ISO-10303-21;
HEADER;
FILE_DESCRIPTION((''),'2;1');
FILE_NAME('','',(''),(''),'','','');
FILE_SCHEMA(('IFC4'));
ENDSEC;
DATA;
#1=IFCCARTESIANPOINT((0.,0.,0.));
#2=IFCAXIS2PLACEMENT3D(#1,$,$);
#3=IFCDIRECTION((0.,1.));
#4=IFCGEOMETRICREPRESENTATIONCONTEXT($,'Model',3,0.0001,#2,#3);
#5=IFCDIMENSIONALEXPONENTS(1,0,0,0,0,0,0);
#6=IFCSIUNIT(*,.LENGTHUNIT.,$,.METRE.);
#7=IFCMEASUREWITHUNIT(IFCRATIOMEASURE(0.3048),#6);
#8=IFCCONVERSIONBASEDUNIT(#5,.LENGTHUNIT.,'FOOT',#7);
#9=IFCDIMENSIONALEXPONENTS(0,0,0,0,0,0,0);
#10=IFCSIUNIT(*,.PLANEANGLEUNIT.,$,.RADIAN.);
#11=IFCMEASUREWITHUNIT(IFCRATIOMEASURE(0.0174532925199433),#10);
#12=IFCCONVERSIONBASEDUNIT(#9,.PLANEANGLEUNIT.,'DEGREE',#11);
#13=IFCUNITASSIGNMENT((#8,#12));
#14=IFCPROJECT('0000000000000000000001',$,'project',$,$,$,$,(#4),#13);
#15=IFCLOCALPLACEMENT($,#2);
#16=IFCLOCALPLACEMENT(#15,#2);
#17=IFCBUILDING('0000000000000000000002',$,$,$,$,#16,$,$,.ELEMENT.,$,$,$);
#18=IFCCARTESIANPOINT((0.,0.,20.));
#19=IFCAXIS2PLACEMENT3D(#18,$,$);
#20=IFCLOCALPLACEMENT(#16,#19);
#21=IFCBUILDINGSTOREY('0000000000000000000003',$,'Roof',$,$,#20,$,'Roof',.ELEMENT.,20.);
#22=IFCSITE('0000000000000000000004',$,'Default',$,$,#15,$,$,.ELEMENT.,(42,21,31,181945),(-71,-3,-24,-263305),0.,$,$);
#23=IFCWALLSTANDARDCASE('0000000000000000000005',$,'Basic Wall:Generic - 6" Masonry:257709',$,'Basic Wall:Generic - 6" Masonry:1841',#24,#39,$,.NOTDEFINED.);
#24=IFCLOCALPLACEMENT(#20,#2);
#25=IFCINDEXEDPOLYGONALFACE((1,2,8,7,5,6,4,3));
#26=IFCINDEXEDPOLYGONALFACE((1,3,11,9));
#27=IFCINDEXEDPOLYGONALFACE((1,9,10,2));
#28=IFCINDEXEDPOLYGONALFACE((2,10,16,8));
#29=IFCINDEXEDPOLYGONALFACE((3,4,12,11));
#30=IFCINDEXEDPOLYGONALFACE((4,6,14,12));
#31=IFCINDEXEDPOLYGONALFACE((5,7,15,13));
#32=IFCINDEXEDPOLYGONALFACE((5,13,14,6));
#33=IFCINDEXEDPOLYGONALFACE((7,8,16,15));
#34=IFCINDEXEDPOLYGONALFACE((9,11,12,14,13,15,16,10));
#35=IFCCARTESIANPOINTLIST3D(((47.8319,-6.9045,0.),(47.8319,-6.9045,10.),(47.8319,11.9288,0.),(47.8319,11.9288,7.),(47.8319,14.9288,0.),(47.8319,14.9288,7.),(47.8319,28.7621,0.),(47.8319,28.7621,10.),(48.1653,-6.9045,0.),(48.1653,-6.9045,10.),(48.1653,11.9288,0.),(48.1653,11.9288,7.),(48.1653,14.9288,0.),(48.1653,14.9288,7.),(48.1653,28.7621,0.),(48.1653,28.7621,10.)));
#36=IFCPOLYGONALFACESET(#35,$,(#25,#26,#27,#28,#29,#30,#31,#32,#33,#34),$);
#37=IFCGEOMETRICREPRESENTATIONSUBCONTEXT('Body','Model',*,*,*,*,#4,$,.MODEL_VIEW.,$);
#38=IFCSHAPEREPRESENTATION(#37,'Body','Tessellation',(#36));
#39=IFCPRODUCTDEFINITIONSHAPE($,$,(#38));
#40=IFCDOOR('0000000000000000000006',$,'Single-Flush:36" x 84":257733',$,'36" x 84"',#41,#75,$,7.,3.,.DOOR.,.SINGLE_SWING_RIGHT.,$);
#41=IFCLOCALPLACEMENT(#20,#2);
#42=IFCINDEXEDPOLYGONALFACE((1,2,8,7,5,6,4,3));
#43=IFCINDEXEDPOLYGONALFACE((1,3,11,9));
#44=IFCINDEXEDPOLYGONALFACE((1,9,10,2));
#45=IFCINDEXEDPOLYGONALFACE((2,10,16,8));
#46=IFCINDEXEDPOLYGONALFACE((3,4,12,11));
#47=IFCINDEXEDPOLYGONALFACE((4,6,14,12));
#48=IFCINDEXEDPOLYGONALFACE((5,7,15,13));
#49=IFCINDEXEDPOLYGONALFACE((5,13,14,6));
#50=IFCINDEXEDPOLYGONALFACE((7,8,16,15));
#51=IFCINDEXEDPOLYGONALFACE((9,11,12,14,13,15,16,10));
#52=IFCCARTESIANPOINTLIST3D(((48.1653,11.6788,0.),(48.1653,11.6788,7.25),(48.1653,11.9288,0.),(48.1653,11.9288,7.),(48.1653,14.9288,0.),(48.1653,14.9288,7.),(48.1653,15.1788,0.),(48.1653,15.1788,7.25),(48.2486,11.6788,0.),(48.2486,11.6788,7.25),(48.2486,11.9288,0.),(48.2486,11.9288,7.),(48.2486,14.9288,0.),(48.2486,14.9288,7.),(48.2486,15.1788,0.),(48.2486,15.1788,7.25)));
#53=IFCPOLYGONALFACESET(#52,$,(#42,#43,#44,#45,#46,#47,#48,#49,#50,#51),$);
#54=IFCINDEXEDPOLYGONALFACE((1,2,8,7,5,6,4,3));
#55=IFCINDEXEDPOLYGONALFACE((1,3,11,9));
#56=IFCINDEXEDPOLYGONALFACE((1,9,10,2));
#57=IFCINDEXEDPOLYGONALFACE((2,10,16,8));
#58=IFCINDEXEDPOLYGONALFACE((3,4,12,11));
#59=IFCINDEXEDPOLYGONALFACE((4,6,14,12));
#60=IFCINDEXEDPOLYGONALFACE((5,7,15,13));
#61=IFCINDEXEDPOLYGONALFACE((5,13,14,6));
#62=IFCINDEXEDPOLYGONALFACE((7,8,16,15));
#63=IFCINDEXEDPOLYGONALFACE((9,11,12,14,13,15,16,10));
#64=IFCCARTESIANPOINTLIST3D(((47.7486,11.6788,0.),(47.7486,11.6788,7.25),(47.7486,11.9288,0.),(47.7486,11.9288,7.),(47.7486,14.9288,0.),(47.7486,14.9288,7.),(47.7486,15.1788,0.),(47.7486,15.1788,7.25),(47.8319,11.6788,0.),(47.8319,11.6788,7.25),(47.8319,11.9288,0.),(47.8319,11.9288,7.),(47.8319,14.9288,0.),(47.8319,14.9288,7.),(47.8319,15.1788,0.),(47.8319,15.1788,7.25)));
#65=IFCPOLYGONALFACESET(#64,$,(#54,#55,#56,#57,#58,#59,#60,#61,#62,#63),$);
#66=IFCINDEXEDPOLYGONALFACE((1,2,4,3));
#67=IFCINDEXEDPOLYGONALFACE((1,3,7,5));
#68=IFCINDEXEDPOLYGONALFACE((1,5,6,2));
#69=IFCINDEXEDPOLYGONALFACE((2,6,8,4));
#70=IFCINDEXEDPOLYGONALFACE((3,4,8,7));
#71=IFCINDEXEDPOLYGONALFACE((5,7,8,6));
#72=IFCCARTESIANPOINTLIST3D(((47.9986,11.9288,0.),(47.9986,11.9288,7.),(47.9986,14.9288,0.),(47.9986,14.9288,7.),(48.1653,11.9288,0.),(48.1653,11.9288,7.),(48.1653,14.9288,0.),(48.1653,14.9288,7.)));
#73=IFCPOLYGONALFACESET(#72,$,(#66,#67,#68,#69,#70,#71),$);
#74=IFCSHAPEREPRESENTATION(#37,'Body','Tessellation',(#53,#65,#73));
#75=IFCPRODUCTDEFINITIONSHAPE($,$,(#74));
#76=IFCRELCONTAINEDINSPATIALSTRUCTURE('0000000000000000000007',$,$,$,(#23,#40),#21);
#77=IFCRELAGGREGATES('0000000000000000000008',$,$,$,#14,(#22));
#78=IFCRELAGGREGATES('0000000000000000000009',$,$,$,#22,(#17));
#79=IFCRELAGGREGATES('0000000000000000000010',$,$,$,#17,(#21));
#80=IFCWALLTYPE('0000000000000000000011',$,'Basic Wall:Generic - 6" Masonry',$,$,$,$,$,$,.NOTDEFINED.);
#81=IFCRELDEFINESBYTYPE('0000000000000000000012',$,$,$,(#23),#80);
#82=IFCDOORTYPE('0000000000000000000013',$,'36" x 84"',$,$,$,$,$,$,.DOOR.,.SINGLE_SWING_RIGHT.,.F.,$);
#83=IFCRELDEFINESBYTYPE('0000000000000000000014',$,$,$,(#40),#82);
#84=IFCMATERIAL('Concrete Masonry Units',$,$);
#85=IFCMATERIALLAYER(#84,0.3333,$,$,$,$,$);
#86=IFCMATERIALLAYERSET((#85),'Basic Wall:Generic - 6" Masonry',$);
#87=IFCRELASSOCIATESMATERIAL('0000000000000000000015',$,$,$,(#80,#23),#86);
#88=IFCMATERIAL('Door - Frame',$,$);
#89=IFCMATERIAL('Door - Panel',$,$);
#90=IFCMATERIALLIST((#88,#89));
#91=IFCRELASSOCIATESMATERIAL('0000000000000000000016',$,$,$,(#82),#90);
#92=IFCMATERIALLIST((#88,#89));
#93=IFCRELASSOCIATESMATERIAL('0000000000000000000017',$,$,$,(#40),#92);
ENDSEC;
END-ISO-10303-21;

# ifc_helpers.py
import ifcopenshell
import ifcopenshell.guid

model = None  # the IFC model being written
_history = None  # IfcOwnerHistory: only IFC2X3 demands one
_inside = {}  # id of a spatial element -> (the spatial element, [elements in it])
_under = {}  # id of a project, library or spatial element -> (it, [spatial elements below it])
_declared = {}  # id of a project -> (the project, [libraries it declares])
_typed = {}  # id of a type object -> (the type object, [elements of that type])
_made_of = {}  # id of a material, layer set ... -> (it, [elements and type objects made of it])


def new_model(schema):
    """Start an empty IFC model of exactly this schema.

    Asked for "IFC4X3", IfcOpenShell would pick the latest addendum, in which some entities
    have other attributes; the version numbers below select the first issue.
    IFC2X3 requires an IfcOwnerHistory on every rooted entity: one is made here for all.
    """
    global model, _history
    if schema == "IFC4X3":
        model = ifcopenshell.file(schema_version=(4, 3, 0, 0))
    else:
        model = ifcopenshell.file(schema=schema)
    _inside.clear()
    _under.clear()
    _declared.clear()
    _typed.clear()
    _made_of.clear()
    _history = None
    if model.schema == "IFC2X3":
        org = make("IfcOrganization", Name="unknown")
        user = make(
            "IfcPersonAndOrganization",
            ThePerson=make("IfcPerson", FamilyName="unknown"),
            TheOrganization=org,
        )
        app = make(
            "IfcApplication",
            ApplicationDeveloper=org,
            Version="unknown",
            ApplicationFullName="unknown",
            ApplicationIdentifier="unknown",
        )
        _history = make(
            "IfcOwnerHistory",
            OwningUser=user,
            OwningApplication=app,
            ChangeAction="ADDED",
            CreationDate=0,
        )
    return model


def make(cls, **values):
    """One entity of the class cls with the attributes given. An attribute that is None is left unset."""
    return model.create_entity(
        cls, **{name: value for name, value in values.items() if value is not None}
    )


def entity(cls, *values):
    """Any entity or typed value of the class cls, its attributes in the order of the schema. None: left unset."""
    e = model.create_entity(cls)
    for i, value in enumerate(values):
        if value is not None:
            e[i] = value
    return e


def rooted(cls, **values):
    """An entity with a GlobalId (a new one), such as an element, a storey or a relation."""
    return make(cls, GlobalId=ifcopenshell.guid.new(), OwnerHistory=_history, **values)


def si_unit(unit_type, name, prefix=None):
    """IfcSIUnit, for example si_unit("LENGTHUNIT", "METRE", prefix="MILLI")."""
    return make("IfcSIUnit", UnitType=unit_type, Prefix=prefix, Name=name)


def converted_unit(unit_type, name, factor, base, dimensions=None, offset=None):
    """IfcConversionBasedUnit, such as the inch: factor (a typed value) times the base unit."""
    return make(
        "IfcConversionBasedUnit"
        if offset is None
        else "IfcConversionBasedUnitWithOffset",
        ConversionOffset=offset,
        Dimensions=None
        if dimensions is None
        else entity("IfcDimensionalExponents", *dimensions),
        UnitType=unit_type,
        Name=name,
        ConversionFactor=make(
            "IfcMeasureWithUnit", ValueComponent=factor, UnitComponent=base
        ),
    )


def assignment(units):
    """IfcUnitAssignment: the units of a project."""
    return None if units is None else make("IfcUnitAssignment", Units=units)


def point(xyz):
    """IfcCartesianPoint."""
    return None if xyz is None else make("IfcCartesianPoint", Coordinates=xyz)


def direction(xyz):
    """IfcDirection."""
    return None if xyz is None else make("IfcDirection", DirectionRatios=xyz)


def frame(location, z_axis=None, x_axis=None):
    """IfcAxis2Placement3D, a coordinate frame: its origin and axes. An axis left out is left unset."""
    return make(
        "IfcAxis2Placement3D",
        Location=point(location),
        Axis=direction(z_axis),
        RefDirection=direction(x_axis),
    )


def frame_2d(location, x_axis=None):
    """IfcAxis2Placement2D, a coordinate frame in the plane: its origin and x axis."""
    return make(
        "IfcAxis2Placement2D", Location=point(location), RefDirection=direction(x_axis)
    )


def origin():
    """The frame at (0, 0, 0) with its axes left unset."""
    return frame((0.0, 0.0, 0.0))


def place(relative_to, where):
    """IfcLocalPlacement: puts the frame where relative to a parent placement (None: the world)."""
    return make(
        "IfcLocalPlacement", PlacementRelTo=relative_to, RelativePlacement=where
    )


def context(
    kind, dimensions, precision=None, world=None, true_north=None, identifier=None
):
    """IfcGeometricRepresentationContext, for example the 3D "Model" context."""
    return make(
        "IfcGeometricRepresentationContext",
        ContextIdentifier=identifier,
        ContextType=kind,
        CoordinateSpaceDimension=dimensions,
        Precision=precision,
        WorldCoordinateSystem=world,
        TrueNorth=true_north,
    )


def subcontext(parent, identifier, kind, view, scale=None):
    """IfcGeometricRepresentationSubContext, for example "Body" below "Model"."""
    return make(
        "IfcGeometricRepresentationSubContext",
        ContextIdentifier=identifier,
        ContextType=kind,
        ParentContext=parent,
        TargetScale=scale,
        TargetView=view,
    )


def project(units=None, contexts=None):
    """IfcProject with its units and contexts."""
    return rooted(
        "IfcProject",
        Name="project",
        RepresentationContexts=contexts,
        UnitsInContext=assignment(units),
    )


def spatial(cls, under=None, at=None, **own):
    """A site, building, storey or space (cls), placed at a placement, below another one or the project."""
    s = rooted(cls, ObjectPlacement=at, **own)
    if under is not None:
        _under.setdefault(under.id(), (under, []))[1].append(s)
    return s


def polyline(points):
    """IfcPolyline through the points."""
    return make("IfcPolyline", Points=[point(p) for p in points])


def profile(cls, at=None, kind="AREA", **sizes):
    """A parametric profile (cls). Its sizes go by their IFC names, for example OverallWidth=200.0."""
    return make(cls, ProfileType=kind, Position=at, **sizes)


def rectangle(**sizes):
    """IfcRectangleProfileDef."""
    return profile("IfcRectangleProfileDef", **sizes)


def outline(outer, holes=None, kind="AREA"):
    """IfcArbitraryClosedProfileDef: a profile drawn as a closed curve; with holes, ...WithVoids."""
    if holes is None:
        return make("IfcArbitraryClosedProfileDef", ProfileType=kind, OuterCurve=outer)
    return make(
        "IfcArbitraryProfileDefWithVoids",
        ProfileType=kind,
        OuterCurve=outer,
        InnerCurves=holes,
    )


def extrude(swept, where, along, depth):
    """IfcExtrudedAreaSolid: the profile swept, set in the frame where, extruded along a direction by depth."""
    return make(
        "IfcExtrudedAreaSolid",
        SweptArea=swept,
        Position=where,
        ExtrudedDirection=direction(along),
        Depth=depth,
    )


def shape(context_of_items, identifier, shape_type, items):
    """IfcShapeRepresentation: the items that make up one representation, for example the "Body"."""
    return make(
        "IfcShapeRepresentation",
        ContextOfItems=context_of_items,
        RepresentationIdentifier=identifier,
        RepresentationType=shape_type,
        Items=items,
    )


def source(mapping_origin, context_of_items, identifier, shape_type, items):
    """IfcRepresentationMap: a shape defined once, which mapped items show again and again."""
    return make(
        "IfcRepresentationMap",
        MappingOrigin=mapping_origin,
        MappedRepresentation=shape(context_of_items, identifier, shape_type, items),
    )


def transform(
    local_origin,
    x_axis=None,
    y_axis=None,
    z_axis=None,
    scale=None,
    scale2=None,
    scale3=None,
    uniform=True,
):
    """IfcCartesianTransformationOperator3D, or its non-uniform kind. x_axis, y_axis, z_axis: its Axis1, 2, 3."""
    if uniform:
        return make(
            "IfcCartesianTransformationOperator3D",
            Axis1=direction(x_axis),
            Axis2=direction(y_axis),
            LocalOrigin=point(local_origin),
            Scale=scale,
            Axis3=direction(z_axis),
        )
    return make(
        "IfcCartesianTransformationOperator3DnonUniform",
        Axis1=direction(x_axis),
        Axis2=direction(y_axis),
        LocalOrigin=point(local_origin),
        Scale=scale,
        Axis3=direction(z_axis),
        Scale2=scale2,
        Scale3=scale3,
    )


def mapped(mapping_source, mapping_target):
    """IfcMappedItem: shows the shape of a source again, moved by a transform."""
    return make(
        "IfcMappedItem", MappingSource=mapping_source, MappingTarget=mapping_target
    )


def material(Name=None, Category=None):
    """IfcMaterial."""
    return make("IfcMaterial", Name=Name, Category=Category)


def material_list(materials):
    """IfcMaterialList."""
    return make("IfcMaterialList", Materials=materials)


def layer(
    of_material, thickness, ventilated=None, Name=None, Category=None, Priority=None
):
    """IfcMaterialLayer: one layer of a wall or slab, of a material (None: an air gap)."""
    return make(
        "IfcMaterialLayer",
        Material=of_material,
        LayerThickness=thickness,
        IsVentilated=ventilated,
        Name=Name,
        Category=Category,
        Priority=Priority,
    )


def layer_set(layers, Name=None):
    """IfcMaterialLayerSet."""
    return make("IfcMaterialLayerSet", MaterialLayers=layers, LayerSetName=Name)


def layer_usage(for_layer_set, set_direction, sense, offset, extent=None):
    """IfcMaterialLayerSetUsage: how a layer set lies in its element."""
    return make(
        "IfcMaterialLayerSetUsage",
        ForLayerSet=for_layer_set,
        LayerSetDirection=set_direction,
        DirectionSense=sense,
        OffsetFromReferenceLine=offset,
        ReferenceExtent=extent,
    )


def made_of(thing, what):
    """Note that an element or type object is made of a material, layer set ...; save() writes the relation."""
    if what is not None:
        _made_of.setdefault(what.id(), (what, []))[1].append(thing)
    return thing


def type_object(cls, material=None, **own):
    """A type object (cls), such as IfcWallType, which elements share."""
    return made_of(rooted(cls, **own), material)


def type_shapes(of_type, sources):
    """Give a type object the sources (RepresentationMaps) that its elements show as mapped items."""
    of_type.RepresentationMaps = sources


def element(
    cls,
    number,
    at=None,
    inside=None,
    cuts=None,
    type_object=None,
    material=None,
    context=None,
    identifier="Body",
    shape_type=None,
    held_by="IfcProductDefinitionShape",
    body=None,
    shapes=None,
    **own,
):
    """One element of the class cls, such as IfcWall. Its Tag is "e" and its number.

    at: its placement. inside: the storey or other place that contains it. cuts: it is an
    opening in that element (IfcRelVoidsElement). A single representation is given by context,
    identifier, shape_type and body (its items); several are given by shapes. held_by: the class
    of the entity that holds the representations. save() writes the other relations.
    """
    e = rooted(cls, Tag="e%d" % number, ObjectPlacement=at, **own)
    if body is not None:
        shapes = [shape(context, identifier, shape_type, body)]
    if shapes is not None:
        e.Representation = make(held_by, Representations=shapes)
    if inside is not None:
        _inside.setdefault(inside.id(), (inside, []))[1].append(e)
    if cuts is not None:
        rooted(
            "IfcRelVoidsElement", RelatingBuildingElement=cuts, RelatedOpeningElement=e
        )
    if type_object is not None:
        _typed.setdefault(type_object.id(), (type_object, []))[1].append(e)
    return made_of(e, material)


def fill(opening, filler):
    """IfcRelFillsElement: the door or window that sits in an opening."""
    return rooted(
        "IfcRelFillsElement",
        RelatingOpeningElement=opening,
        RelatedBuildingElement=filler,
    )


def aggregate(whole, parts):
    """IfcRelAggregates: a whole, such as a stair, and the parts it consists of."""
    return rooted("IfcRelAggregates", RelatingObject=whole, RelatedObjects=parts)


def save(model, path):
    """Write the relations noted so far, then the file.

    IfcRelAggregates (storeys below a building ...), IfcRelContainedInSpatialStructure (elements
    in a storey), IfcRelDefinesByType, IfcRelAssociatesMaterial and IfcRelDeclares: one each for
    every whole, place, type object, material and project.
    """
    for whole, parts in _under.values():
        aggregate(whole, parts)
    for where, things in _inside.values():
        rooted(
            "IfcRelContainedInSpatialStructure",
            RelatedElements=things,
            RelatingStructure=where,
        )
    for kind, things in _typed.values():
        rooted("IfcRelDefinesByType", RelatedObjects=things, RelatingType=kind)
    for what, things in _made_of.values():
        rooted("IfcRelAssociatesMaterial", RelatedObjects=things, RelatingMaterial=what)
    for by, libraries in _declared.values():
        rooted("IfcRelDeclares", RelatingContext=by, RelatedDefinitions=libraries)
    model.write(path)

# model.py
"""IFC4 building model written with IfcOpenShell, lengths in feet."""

from ifc_helpers import new_model, entity, si_unit, converted_unit, direction, frame, frame_2d, origin, place, context, subcontext, project, spatial, polyline, rectangle, outline, extrude, source, transform, mapped, material, material_list, layer, layer_set, layer_usage, type_object, type_shapes, element, fill, save


model = new_model("IFC4")

# Units and contexts
model_context = context("Model", 3, precision=0.0001, world=origin(), true_north=direction((0.0, 1.0)))
body_context = subcontext(model_context, "Body", "Model", "MODEL_VIEW")
ifc_project = project(units=[converted_unit("LENGTHUNIT", "FOOT", entity("IfcRatioMeasure", 0.3048), si_unit("LENGTHUNIT", "METRE"), dimensions=[1, 0, 0, 0, 0, 0, 0]), converted_unit("PLANEANGLEUNIT", "DEGREE", entity("IfcRatioMeasure", 0.0174532925199433), si_unit("PLANEANGLEUNIT", "RADIAN"), dimensions=[0, 0, 0, 0, 0, 0, 0])], contexts=[model_context])

# Site, building, storey
site_placement = place(None, origin())
site = spatial("IfcSite", under=ifc_project, at=site_placement, Name="Default", CompositionType="ELEMENT", RefLatitude=(42, 21, 31, 181945), RefLongitude=(-71, -3, -24, -263305), RefElevation=0.0)
building_placement = place(site_placement, origin())
building = spatial("IfcBuilding", under=site, at=building_placement, CompositionType="ELEMENT")
storey_placement = place(building_placement, frame((0.0, 0.0, 20.0)))
storey = spatial("IfcBuildingStorey", under=building, at=storey_placement, Name="Roof", LongName="Roof", CompositionType="ELEMENT", Elevation=20.0)

# Wall, opening, door
ifc_material_1 = material(Name="Concrete Masonry Units")
ifc_layer = layer(ifc_material_1, 0.3333)
ifc_layer_set = layer_set([ifc_layer], Name="Basic Wall:Generic - 6\" Masonry")
ifc_layer_usage = layer_usage(ifc_layer_set, "AXIS2", "NEGATIVE", 0.1667)
wall_type = type_object("IfcWallType", Name="Basic Wall:Generic - 6\" Masonry", PredefinedType="NOTDEFINED", material=ifc_layer_set)
wall_placement = place(storey_placement, frame((47.9986, 28.7621, 0.0), z_axis=(0.0, 0.0, 1.0), x_axis=(0.0, -1.0, 0.0)))
wall = element("IfcWallStandardCase", 1, at=wall_placement, inside=storey, type_object=wall_type, material=ifc_layer_usage, Name="Basic Wall:Generic - 6\" Masonry:257709", ObjectType="Basic Wall:Generic - 6\" Masonry:1841", PredefinedType="NOTDEFINED", context=body_context, shape_type="SweptSolid", body=[
    extrude(rectangle(XDim=35.6667, YDim=0.3333, at=frame_2d((17.8333, 0.0), x_axis=(-1.0, 0.0))), origin(), (0.0, 0.0, 1.0), 10.0),
])
opening_placement = place(wall_placement, frame((13.8333, -0.1667, 0.0)))
opening = element("IfcOpeningElement", 2, at=opening_placement, cuts=wall, ObjectType="Opening", PredefinedType="OPENING", context=body_context, shape_type="SweptSolid", body=[
    extrude(rectangle(XDim=3.0, YDim=7.0, at=frame_2d((3.5, 1.5), x_axis=(0.0, 1.0))), frame((0.0, 0.0, 0.0), z_axis=(0.0, 1.0, 0.0), x_axis=(0.0, 0.0, 1.0)), (0.0, 0.0, 1.0), 0.3333),
])
ifc_material_2 = material(Name="Door - Frame")
ifc_material_3 = material(Name="Door - Panel")
ifc_material_list_1 = material_list([ifc_material_2, ifc_material_3])
ifc_material_list_2 = material_list([ifc_material_2, ifc_material_3])
door_type = type_object("IfcDoorType", Name="36\" x 84\"", OperationType="SINGLE_SWING_RIGHT", ParameterTakesPrecedence=False, PredefinedType="DOOR", material=ifc_material_list_2)
shared_shape = source(origin(), body_context, "Body", "SweptSolid", [
    extrude(outline(polyline([(-1.75, -3.6875), (1.75, -3.6875), (1.75, 3.5625), (1.5, 3.5625), (1.5, -3.4375), (-1.5, -3.4375), (-1.5, 3.5625), (-1.75, 3.5625), (-1.75, -3.6875)])), frame((1.5, 0.3333, 3.5625), z_axis=(0.0, 1.0, 0.0), x_axis=(1.0, 0.0, 0.0)), (0.0, 0.0, 1.0), 0.0833),
    extrude(outline(polyline([(-3.6875, -1.75), (3.5625, -1.75), (3.5625, -1.5), (-3.4375, -1.5), (-3.4375, 1.5), (3.5625, 1.5), (3.5625, 1.75), (-3.6875, 1.75), (-3.6875, -1.75)])), frame((1.5, -0.0833, 3.5625), z_axis=(0.0, 1.0, 0.0), x_axis=(0.0, 0.0, -1.0)), (0.0, 0.0, 1.0), 0.0833),
    extrude(rectangle(XDim=0.1667, YDim=3.0, at=frame_2d((0.0, 0.0), x_axis=(1.0, 0.0))), frame((1.5, 0.25, 0.0), z_axis=(0.0, 0.0, 1.0), x_axis=(0.0, 1.0, 0.0)), (0.0, 0.0, 1.0), 7.0),
])
type_shapes(door_type, [shared_shape])
door_placement = place(opening_placement, origin())
door = element("IfcDoor", 3, at=door_placement, inside=storey, type_object=door_type, material=ifc_material_list_1, Name="Single-Flush:36\" x 84\":257733", ObjectType="36\" x 84\"", OperationType="SINGLE_SWING_RIGHT", OverallHeight=7.0, OverallWidth=3.0, PredefinedType="DOOR", context=body_context, shape_type="MappedRepresentation", body=[
    mapped(shared_shape, transform((0.0, 0.0, 0.0), scale=1.0)),
])
fill(opening, door)

save(model, "model.ifc")
